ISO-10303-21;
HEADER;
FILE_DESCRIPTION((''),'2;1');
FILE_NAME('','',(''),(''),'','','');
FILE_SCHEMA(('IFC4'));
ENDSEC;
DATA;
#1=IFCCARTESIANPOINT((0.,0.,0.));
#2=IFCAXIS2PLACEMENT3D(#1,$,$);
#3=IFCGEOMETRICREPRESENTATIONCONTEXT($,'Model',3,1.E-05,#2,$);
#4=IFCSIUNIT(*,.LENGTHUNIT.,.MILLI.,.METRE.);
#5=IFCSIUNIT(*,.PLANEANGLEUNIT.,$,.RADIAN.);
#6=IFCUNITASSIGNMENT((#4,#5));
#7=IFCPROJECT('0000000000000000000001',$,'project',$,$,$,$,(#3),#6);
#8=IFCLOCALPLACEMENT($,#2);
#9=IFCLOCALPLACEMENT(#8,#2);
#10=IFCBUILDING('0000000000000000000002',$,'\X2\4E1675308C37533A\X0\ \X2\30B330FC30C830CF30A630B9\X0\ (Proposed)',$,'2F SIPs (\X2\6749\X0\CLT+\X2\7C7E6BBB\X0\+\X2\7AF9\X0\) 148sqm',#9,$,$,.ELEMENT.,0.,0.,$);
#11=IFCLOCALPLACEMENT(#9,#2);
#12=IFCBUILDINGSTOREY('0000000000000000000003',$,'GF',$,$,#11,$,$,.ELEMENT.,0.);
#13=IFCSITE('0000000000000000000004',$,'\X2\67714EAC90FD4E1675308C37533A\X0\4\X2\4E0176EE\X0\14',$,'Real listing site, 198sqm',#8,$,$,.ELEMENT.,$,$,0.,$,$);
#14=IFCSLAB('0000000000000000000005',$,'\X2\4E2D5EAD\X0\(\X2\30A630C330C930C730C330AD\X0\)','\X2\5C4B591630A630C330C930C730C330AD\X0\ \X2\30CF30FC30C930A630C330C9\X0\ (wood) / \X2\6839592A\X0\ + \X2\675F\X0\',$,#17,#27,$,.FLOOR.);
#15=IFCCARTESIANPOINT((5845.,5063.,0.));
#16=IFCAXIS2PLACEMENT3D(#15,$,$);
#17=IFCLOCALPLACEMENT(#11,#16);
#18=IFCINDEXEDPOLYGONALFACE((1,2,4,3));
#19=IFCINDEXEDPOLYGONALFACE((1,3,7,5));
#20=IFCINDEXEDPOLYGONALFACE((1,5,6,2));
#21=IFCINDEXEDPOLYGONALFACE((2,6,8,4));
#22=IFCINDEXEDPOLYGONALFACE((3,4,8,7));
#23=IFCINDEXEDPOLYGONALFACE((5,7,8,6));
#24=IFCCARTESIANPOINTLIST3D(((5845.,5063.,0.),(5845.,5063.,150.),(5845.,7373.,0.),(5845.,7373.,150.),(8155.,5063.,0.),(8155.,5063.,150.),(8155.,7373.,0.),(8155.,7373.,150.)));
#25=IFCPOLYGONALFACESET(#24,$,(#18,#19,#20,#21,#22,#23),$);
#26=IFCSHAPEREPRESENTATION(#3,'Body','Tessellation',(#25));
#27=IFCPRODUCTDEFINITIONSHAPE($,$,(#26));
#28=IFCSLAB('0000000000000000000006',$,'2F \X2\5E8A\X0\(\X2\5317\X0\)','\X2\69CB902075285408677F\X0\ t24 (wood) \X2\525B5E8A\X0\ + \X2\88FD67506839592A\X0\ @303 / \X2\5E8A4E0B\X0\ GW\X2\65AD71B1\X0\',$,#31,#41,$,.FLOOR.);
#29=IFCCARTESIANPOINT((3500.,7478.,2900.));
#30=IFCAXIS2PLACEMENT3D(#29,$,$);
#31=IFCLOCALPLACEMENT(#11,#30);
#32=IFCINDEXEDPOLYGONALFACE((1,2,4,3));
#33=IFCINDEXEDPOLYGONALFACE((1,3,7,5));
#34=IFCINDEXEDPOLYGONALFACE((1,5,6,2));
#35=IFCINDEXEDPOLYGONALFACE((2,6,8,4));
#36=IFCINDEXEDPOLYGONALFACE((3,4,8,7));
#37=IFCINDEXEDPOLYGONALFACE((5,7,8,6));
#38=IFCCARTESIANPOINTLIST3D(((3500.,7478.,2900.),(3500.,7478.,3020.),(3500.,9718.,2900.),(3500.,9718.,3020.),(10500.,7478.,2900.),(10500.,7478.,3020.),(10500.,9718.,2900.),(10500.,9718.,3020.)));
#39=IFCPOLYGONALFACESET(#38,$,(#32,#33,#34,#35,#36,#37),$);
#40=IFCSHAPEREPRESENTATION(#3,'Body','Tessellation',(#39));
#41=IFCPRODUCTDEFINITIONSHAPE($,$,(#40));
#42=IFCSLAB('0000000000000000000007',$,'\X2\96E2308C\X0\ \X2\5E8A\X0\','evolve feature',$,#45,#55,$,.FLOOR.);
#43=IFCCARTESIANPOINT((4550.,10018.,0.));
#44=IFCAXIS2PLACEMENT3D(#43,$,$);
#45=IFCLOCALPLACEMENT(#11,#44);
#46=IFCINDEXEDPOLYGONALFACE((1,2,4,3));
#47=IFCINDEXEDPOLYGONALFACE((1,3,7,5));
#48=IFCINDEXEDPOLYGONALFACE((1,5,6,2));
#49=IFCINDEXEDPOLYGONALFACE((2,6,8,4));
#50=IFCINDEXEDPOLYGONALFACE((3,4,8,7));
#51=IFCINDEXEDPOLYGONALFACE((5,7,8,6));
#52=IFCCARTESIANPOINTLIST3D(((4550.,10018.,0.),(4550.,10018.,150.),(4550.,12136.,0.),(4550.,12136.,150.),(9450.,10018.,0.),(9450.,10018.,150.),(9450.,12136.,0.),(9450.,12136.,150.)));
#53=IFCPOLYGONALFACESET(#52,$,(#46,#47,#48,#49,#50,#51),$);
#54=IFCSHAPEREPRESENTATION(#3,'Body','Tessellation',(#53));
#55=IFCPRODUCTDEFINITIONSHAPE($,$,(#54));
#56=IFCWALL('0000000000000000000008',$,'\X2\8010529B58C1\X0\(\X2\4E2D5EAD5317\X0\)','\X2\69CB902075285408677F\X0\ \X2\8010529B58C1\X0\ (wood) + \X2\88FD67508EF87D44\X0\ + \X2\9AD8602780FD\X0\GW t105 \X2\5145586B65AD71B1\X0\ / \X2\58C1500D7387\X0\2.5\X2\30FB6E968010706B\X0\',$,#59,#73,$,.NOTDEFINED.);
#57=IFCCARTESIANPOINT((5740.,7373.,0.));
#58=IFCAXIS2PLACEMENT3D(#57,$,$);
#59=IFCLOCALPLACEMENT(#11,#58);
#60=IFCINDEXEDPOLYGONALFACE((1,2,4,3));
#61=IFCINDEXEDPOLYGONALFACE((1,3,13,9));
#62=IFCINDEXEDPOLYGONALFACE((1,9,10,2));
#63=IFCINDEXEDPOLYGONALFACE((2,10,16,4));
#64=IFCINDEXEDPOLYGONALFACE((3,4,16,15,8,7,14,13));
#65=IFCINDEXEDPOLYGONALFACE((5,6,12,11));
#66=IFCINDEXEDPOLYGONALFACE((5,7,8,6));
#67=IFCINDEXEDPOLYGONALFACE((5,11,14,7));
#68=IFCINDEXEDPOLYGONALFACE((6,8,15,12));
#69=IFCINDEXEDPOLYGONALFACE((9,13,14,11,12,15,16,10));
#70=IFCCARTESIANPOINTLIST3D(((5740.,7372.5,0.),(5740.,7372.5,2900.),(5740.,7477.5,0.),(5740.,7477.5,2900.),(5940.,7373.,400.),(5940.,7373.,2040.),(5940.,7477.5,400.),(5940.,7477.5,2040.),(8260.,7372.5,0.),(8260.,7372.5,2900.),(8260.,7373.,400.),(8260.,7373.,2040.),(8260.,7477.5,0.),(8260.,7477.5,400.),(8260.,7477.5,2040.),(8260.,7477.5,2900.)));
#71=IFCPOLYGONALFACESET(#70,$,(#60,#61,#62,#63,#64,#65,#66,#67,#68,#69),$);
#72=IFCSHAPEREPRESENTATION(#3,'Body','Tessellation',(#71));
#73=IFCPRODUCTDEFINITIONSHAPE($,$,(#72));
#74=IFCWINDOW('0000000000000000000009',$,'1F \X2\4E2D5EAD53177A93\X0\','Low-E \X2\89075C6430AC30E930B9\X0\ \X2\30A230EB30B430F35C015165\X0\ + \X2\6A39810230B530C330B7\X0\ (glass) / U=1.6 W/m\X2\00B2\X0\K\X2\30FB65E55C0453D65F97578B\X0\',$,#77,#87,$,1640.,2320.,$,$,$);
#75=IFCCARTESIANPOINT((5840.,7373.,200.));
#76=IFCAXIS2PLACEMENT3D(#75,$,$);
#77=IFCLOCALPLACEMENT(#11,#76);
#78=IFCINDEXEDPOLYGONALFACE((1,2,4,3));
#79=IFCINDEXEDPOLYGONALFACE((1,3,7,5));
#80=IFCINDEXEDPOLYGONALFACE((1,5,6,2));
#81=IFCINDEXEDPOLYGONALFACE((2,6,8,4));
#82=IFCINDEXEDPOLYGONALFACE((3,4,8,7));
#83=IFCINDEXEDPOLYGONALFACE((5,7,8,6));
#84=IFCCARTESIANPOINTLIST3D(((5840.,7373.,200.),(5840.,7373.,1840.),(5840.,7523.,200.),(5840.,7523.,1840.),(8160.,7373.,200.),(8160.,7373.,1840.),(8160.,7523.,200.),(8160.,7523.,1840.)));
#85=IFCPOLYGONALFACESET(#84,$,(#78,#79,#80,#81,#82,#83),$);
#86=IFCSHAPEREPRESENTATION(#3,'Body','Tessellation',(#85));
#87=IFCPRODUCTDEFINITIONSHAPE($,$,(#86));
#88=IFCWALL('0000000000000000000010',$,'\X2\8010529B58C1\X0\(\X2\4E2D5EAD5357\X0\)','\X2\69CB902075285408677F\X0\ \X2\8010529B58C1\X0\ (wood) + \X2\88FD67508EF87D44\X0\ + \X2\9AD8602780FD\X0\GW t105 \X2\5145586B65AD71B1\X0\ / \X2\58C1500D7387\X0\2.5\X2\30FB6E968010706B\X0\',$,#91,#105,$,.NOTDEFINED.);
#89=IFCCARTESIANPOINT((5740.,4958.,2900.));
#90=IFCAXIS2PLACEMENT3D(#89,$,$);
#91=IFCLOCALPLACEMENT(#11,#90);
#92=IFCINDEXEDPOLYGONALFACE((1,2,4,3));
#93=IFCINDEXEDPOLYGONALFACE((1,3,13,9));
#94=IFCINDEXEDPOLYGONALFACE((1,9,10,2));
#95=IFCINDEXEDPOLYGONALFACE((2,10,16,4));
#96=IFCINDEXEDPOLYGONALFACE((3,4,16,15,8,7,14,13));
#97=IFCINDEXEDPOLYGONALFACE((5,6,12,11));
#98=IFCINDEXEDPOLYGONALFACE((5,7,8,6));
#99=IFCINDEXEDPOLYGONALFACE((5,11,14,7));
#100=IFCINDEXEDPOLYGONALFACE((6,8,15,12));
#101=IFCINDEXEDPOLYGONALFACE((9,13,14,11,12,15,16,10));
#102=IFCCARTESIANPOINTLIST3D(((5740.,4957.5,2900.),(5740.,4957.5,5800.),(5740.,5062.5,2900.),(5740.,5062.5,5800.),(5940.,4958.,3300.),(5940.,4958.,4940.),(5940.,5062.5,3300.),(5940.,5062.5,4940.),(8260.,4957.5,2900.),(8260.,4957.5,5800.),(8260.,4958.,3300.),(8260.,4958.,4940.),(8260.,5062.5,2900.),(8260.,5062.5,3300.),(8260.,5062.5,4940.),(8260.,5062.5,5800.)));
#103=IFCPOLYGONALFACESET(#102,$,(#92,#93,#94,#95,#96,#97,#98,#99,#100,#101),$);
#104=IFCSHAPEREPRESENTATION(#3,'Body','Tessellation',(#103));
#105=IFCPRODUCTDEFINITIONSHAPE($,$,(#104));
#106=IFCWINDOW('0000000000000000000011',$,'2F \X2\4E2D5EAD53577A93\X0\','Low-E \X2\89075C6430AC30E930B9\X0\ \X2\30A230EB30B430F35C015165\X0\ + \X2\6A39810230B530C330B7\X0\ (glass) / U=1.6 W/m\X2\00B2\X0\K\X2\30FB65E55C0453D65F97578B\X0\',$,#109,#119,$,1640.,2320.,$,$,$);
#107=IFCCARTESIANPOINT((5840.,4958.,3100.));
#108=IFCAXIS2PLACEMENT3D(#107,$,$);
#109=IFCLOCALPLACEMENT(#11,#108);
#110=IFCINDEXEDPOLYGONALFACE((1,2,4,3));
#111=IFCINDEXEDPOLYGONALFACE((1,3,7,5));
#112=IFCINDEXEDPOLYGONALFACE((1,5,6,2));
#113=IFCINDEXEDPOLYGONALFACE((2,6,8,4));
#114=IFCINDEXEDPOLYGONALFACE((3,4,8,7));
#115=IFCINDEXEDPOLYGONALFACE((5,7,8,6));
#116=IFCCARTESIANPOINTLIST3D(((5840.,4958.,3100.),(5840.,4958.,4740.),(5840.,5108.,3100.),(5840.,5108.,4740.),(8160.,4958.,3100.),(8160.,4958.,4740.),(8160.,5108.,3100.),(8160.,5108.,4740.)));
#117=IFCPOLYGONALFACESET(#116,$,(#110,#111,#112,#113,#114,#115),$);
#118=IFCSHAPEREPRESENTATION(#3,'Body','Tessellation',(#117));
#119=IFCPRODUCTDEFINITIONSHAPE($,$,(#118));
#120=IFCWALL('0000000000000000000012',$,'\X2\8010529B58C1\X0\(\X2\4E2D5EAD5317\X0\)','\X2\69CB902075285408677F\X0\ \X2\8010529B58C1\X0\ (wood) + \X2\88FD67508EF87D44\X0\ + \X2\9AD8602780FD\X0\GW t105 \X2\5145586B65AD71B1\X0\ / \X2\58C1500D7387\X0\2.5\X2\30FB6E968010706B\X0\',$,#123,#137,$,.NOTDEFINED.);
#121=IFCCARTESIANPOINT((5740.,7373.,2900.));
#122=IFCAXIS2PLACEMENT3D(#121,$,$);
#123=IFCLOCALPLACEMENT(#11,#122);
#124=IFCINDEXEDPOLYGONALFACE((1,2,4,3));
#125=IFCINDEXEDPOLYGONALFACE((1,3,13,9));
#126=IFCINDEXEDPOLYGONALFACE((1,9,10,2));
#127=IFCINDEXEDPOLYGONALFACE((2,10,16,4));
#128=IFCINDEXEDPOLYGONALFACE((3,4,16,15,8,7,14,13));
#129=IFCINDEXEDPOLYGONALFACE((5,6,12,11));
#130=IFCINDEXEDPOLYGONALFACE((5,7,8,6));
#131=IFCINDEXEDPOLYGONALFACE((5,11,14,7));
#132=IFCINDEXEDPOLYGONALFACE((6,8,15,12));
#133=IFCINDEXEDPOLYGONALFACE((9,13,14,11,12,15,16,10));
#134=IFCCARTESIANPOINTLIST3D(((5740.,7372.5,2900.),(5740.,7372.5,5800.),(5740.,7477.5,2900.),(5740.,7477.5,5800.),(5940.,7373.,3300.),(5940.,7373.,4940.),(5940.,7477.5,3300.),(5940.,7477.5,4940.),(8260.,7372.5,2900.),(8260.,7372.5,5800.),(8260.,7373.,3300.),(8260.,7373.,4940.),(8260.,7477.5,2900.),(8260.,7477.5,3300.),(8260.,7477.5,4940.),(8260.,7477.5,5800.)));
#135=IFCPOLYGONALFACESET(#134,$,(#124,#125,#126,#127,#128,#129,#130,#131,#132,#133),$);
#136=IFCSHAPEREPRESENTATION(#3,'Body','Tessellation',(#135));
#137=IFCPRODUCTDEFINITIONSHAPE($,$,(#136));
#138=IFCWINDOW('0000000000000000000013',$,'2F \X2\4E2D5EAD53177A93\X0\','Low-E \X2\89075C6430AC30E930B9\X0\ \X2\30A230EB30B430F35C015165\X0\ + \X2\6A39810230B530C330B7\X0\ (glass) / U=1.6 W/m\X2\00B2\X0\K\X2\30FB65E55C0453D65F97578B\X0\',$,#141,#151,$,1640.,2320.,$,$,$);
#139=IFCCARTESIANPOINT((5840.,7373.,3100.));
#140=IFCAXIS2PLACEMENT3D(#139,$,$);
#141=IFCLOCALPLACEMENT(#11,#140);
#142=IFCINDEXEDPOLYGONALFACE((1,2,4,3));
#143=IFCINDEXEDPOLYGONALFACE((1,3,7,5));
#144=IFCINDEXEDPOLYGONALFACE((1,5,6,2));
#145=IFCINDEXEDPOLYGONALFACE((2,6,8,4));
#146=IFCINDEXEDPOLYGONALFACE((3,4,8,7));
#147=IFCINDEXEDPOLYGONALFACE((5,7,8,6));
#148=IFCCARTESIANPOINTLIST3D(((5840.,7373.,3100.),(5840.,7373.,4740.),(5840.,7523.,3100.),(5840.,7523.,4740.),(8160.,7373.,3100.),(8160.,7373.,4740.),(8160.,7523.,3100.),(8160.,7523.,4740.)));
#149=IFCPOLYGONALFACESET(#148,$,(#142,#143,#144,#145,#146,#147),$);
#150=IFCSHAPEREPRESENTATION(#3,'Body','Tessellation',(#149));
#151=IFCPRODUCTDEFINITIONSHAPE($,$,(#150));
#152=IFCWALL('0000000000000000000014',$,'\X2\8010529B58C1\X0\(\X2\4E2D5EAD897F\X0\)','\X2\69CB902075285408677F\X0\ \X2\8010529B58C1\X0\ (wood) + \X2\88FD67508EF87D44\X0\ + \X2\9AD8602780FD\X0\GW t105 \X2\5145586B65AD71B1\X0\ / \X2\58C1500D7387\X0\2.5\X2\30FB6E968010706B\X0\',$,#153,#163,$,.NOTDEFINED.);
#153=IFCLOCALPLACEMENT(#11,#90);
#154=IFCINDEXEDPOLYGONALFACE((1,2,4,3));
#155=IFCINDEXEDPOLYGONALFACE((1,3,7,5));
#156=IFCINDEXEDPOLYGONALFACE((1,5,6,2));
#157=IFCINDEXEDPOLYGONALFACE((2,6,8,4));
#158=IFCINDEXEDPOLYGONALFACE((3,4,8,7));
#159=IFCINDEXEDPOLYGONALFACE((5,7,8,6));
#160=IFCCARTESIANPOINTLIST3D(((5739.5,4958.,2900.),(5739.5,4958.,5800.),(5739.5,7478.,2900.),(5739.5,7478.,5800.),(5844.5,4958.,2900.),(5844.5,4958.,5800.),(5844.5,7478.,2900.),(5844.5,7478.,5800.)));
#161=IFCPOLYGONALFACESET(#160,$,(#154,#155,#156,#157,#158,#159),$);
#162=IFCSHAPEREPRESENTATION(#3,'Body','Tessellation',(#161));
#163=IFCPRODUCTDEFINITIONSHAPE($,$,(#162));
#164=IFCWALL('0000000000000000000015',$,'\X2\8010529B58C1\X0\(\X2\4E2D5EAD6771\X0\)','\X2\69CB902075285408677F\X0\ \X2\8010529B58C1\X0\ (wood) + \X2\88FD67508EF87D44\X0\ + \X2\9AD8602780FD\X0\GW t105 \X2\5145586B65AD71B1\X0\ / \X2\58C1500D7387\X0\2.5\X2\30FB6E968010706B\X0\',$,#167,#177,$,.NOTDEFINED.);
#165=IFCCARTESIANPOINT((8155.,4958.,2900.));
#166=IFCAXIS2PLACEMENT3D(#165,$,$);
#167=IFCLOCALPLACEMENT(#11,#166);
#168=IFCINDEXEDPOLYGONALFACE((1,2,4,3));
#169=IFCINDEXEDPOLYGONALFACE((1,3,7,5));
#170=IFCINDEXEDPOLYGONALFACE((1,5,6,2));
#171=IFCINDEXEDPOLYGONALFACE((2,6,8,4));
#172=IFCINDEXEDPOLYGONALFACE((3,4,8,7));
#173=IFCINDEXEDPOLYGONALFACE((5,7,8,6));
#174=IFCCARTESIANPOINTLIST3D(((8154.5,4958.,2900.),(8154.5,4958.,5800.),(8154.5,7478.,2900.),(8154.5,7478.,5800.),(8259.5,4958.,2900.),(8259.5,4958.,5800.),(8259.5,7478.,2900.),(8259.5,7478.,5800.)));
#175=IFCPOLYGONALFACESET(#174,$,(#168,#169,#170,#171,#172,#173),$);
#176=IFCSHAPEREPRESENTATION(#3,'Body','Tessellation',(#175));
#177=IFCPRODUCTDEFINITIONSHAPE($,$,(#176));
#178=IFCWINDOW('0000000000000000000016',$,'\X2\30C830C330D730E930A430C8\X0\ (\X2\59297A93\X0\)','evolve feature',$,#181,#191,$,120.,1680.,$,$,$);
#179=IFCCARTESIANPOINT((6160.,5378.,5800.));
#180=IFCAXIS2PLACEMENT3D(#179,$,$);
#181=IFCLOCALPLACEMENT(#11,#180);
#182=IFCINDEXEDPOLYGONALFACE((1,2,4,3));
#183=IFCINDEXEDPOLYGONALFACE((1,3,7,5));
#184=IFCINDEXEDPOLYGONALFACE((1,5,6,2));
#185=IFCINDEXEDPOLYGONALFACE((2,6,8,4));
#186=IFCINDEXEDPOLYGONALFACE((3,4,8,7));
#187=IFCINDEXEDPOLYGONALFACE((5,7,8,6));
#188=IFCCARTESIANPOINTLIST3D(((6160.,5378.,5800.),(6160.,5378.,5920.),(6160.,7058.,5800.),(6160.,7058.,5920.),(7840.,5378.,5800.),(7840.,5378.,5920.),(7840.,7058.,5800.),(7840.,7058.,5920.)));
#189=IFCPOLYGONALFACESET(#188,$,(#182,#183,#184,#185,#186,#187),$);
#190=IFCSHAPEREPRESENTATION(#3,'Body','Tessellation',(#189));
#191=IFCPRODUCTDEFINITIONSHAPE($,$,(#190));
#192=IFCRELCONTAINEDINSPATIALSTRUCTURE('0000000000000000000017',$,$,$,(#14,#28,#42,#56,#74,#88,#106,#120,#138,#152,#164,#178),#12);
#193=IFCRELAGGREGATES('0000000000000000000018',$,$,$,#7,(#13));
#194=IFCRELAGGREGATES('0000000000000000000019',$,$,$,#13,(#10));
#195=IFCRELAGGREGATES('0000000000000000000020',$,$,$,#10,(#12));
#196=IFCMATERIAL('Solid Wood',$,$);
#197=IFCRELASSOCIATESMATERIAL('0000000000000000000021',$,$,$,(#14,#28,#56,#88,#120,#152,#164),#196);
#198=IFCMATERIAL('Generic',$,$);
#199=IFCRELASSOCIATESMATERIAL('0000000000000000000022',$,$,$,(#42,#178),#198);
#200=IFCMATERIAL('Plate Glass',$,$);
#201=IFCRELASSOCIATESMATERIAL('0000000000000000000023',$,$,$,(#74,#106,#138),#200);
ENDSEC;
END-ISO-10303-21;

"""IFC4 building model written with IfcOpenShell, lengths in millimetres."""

from ifc_helpers import new_model, si_unit, frame, frame_2d, origin, place, context, project, spatial, rectangle, extrude, material, element, fill, save


model = new_model("IFC4")

# Units and contexts
model_context = context("Model", 3, precision=1e-05, world=origin())
ifc_project = project(units=[si_unit("LENGTHUNIT", "METRE", prefix="MILLI"), si_unit("PLANEANGLEUNIT", "RADIAN")], contexts=[model_context])

# Site, building, storey
site_placement = place(None, origin())
site = spatial("IfcSite", under=ifc_project, at=site_placement, Name="東京都世田谷区4丁目14", ObjectType="Real listing site, 198sqm", CompositionType="ELEMENT", RefElevation=0.0)
building_placement = place(site_placement, origin())
building = spatial("IfcBuilding", under=site, at=building_placement, Name="世田谷区 コートハウス (Proposed)", ObjectType="2F SIPs (杉CLT+籾殻+竹) 148sqm", CompositionType="ELEMENT", ElevationOfRefHeight=0.0, ElevationOfTerrain=0.0)
storey_placement = place(building_placement, origin())
storey = spatial("IfcBuildingStorey", under=building, at=storey_placement, Name="GF", CompositionType="ELEMENT", Elevation=0.0)

# Slabs
ifc_material_1 = material(Name="Solid Wood")
slab_1_placement = place(storey_placement, frame((5845.0, 5063.0, 0.0)))
element("IfcSlab", 1, at=slab_1_placement, inside=storey, material=ifc_material_1, Name="中庭(ウッドデッキ)", Description="屋外ウッドデッキ ハードウッド (wood) / 根太 + 束", PredefinedType="FLOOR", context=model_context, shape_type="SweptSolid", body=[
    extrude(rectangle(XDim=2310.0, YDim=2310.0, at=frame_2d((1155.0, 1155.0))), frame((5845.0, 5063.0, 0.0)), (0.0, 0.0, 1.0), 150.0),
])
slab_2_placement = place(storey_placement, frame((3500.0, 7478.0, 2900.0)))
element("IfcSlab", 2, at=slab_2_placement, inside=storey, material=ifc_material_1, Name="2F 床(北)", Description="構造用合板 t24 (wood) 剛床 + 製材根太 @303 / 床下 GW断熱", PredefinedType="FLOOR", context=model_context, shape_type="SweptSolid", body=[
    extrude(rectangle(XDim=7000.0, YDim=2240.0, at=frame_2d((3500.0, 1120.0))), frame((3500.0, 7478.0, 2900.0)), (0.0, 0.0, 1.0), 120.0),
])
ifc_material_2 = material(Name="Generic")
slab_3_placement = place(storey_placement, frame((4550.0, 10018.0, 0.0)))
element("IfcSlab", 3, at=slab_3_placement, inside=storey, material=ifc_material_2, Name="離れ 床", Description="evolve feature", PredefinedType="FLOOR", context=model_context, shape_type="SweptSolid", body=[
    extrude(rectangle(XDim=4900.0, YDim=2118.0, at=frame_2d((2450.0, 1059.0))), frame((4550.0, 10018.0, 0.0)), (0.0, 0.0, 1.0), 150.0),
])

# Wall, opening, window
wall_1_placement = place(storey_placement, frame((5740.0, 7373.0, 0.0)))
wall_1 = element("IfcWall", 4, at=wall_1_placement, inside=storey, material=ifc_material_1, Name="耐力壁(中庭北)", Description="構造用合板 耐力壁 (wood) + 製材軸組 + 高性能GW t105 充填断熱 / 壁倍率2.5・準耐火", PredefinedType="NOTDEFINED", context=model_context, shape_type="SweptSolid", body=[
    extrude(rectangle(XDim=2520.0, YDim=105.0, at=frame_2d((1260.0, 52.0))), frame((5740.0, 7373.0, 0.0)), (0.0, 0.0, 1.0), 2900.0),
])
opening_1_placement = place(storey_placement, frame((5840.0, 7373.0, 200.0)))
opening_1 = element("IfcOpeningElement", 5, at=opening_1_placement, cuts=wall_1, PredefinedType="NOTDEFINED", context=model_context, shape_type="SweptSolid", body=[
    extrude(rectangle(XDim=2320.0, YDim=150.0, at=frame_2d((1160.0, 75.0))), frame((5840.0, 7373.0, 200.0)), (0.0, 0.0, 1.0), 1640.0),
])
ifc_material_3 = material(Name="Plate Glass")
window_1_placement = place(storey_placement, frame((5840.0, 7373.0, 200.0)))
window_1 = element("IfcWindow", 6, at=window_1_placement, inside=storey, material=ifc_material_3, Name="1F 中庭北窓", Description="Low-E 複層ガラス アルゴン封入 + 樹脂サッシ (glass) / U=1.6 W/m²K・日射取得型", OverallHeight=1640.0, OverallWidth=2320.0, context=model_context, shape_type="SweptSolid", body=[
    extrude(rectangle(XDim=2320.0, YDim=150.0, at=frame_2d((1160.0, 75.0))), frame((5840.0, 7373.0, 200.0)), (0.0, 0.0, 1.0), 1640.0),
])
fill(opening_1, window_1)

# Walls, openings, windows
wall_2_placement = place(storey_placement, frame((5740.0, 4958.0, 2900.0)))
wall_2 = element("IfcWall", 7, at=wall_2_placement, inside=storey, material=ifc_material_1, Name="耐力壁(中庭南)", Description="構造用合板 耐力壁 (wood) + 製材軸組 + 高性能GW t105 充填断熱 / 壁倍率2.5・準耐火", PredefinedType="NOTDEFINED", context=model_context, shape_type="SweptSolid", body=[
    extrude(rectangle(XDim=2520.0, YDim=105.0, at=frame_2d((1260.0, 52.0))), frame((5740.0, 4958.0, 2900.0)), (0.0, 0.0, 1.0), 2900.0),
])
opening_2_placement = place(storey_placement, frame((5840.0, 4958.0, 3100.0)))
opening_2 = element("IfcOpeningElement", 8, at=opening_2_placement, cuts=wall_2, PredefinedType="NOTDEFINED", context=model_context, shape_type="SweptSolid", body=[
    extrude(rectangle(XDim=2320.0, YDim=150.0, at=frame_2d((1160.0, 75.0))), frame((5840.0, 4958.0, 3100.0)), (0.0, 0.0, 1.0), 1640.0),
])
window_2_placement = place(storey_placement, frame((5840.0, 4958.0, 3100.0)))
window_2 = element("IfcWindow", 9, at=window_2_placement, inside=storey, material=ifc_material_3, Name="2F 中庭南窓", Description="Low-E 複層ガラス アルゴン封入 + 樹脂サッシ (glass) / U=1.6 W/m²K・日射取得型", OverallHeight=1640.0, OverallWidth=2320.0, context=model_context, shape_type="SweptSolid", body=[
    extrude(rectangle(XDim=2320.0, YDim=150.0, at=frame_2d((1160.0, 75.0))), frame((5840.0, 4958.0, 3100.0)), (0.0, 0.0, 1.0), 1640.0),
])
fill(opening_2, window_2)
wall_3_placement = place(storey_placement, frame((5740.0, 7373.0, 2900.0)))
wall_3 = element("IfcWall", 10, at=wall_3_placement, inside=storey, material=ifc_material_1, Name="耐力壁(中庭北)", Description="構造用合板 耐力壁 (wood) + 製材軸組 + 高性能GW t105 充填断熱 / 壁倍率2.5・準耐火", PredefinedType="NOTDEFINED", context=model_context, shape_type="SweptSolid", body=[
    extrude(rectangle(XDim=2520.0, YDim=105.0, at=frame_2d((1260.0, 52.0))), frame((5740.0, 7373.0, 2900.0)), (0.0, 0.0, 1.0), 2900.0),
])
opening_3_placement = place(storey_placement, frame((5840.0, 7373.0, 3100.0)))
opening_3 = element("IfcOpeningElement", 11, at=opening_3_placement, cuts=wall_3, PredefinedType="NOTDEFINED", context=model_context, shape_type="SweptSolid", body=[
    extrude(rectangle(XDim=2320.0, YDim=150.0, at=frame_2d((1160.0, 75.0))), frame((5840.0, 7373.0, 3100.0)), (0.0, 0.0, 1.0), 1640.0),
])
window_3_placement = place(storey_placement, frame((5840.0, 7373.0, 3100.0)))
window_3 = element("IfcWindow", 12, at=window_3_placement, inside=storey, material=ifc_material_3, Name="2F 中庭北窓", Description="Low-E 複層ガラス アルゴン封入 + 樹脂サッシ (glass) / U=1.6 W/m²K・日射取得型", OverallHeight=1640.0, OverallWidth=2320.0, context=model_context, shape_type="SweptSolid", body=[
    extrude(rectangle(XDim=2320.0, YDim=150.0, at=frame_2d((1160.0, 75.0))), frame((5840.0, 7373.0, 3100.0)), (0.0, 0.0, 1.0), 1640.0),
])
fill(opening_3, window_3)

# Walls
wall_4_placement = place(storey_placement, frame((5740.0, 4958.0, 2900.0)))
element("IfcWall", 13, at=wall_4_placement, inside=storey, material=ifc_material_1, Name="耐力壁(中庭西)", Description="構造用合板 耐力壁 (wood) + 製材軸組 + 高性能GW t105 充填断熱 / 壁倍率2.5・準耐火", PredefinedType="NOTDEFINED", context=model_context, shape_type="SweptSolid", body=[
    extrude(rectangle(XDim=105.0, YDim=2520.0, at=frame_2d((52.0, 1260.0))), frame((5740.0, 4958.0, 2900.0)), (0.0, 0.0, 1.0), 2900.0),
])
wall_5_placement = place(storey_placement, frame((8155.0, 4958.0, 2900.0)))
element("IfcWall", 14, at=wall_5_placement, inside=storey, material=ifc_material_1, Name="耐力壁(中庭東)", Description="構造用合板 耐力壁 (wood) + 製材軸組 + 高性能GW t105 充填断熱 / 壁倍率2.5・準耐火", PredefinedType="NOTDEFINED", context=model_context, shape_type="SweptSolid", body=[
    extrude(rectangle(XDim=105.0, YDim=2520.0, at=frame_2d((52.0, 1260.0))), frame((8155.0, 4958.0, 2900.0)), (0.0, 0.0, 1.0), 2900.0),
])

# Window
window_4_placement = place(storey_placement, frame((6160.0, 5378.0, 5800.0)))
element("IfcWindow", 15, at=window_4_placement, inside=storey, material=ifc_material_2, Name="トップライト (天窓)", Description="evolve feature", OverallHeight=120.0, OverallWidth=1680.0, context=model_context, shape_type="SweptSolid", body=[
    extrude(rectangle(XDim=1680.0, YDim=1680.0, at=frame_2d((840.0, 840.0))), frame((6160.0, 5378.0, 5800.0)), (0.0, 0.0, 1.0), 120.0),
])

save(model, "model.ifc")
